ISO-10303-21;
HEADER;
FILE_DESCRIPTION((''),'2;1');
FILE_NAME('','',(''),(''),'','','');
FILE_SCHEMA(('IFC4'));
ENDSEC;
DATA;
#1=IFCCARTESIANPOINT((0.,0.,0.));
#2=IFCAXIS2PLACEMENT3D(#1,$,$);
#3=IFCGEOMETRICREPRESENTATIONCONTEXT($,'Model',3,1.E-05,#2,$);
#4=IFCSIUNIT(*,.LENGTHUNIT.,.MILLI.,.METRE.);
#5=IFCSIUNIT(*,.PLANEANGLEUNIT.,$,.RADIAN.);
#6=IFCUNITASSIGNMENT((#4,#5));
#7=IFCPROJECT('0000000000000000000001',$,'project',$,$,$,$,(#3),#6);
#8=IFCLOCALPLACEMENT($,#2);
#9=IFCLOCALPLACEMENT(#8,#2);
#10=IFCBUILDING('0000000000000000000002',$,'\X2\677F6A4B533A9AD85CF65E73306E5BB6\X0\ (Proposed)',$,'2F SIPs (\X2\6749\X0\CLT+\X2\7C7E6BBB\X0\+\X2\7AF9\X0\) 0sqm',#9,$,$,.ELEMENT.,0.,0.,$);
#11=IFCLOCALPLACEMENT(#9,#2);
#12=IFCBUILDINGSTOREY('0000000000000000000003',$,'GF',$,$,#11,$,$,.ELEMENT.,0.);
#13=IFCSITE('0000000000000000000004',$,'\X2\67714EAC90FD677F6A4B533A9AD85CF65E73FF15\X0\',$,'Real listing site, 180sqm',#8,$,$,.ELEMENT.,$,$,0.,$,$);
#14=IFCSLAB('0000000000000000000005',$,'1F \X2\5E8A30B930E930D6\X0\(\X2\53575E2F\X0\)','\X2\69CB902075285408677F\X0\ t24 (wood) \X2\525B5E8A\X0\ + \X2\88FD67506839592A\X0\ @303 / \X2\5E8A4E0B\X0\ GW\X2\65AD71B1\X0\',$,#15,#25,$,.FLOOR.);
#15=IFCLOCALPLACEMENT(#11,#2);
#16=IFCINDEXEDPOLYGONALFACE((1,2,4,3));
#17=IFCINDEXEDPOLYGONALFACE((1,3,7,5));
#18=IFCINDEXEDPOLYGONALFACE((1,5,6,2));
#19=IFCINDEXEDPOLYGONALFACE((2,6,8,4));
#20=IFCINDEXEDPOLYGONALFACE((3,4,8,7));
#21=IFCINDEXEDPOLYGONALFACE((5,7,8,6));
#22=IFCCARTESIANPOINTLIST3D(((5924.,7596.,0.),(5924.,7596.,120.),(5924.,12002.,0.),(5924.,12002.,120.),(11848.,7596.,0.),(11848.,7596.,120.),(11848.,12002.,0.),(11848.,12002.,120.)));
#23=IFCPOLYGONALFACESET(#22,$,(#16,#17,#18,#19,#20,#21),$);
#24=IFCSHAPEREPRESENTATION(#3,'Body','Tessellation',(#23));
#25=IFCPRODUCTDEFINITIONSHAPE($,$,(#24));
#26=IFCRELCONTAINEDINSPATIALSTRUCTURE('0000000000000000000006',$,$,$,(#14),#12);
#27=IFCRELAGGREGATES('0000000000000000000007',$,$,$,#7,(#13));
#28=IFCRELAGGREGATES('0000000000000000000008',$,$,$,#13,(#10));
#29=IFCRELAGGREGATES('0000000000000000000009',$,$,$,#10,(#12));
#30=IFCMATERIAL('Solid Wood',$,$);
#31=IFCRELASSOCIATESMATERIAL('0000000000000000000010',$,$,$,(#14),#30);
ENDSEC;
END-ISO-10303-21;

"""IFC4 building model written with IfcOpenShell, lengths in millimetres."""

from ifc_helpers import new_model, si_unit, frame, frame_2d, origin, place, context, project, spatial, rectangle, extrude, material, element, save


model = new_model("IFC4")

# Units and contexts
model_context = context("Model", 3, precision=1e-05, world=origin())
ifc_project = project(units=[si_unit("LENGTHUNIT", "METRE", prefix="MILLI"), si_unit("PLANEANGLEUNIT", "RADIAN")], contexts=[model_context])

# Site, building, storey
site_placement = place(None, origin())
site = spatial("IfcSite", under=ifc_project, at=site_placement, Name="東京都板橋区高島平５", ObjectType="Real listing site, 180sqm", CompositionType="ELEMENT", RefElevation=0.0)
building_placement = place(site_placement, origin())
building = spatial("IfcBuilding", under=site, at=building_placement, Name="板橋区高島平の家 (Proposed)", ObjectType="2F SIPs (杉CLT+籾殻+竹) 0sqm", CompositionType="ELEMENT", ElevationOfRefHeight=0.0, ElevationOfTerrain=0.0)
storey_placement = place(building_placement, origin())
storey = spatial("IfcBuildingStorey", under=building, at=storey_placement, Name="GF", CompositionType="ELEMENT", Elevation=0.0)

# Slab
ifc_material_1 = material(Name="Solid Wood")
slab_1_placement = place(storey_placement, frame((2962.0, 3798.0, 0.0)))
element("IfcSlab", 1, at=slab_1_placement, inside=storey, material=ifc_material_1, Name="1F 床スラブ(南帯)", Description="構造用合板 t24 (wood) 剛床 + 製材根太 @303 / 床下 GW断熱", PredefinedType="FLOOR", context=model_context, shape_type="SweptSolid", body=[
    extrude(rectangle(XDim=5924.0, YDim=4406.0, at=frame_2d((2962.0, 2203.0))), frame((2962.0, 3798.0, 0.0)), (0.0, 0.0, 1.0), 120.0),
])

save(model, "model.ifc")
